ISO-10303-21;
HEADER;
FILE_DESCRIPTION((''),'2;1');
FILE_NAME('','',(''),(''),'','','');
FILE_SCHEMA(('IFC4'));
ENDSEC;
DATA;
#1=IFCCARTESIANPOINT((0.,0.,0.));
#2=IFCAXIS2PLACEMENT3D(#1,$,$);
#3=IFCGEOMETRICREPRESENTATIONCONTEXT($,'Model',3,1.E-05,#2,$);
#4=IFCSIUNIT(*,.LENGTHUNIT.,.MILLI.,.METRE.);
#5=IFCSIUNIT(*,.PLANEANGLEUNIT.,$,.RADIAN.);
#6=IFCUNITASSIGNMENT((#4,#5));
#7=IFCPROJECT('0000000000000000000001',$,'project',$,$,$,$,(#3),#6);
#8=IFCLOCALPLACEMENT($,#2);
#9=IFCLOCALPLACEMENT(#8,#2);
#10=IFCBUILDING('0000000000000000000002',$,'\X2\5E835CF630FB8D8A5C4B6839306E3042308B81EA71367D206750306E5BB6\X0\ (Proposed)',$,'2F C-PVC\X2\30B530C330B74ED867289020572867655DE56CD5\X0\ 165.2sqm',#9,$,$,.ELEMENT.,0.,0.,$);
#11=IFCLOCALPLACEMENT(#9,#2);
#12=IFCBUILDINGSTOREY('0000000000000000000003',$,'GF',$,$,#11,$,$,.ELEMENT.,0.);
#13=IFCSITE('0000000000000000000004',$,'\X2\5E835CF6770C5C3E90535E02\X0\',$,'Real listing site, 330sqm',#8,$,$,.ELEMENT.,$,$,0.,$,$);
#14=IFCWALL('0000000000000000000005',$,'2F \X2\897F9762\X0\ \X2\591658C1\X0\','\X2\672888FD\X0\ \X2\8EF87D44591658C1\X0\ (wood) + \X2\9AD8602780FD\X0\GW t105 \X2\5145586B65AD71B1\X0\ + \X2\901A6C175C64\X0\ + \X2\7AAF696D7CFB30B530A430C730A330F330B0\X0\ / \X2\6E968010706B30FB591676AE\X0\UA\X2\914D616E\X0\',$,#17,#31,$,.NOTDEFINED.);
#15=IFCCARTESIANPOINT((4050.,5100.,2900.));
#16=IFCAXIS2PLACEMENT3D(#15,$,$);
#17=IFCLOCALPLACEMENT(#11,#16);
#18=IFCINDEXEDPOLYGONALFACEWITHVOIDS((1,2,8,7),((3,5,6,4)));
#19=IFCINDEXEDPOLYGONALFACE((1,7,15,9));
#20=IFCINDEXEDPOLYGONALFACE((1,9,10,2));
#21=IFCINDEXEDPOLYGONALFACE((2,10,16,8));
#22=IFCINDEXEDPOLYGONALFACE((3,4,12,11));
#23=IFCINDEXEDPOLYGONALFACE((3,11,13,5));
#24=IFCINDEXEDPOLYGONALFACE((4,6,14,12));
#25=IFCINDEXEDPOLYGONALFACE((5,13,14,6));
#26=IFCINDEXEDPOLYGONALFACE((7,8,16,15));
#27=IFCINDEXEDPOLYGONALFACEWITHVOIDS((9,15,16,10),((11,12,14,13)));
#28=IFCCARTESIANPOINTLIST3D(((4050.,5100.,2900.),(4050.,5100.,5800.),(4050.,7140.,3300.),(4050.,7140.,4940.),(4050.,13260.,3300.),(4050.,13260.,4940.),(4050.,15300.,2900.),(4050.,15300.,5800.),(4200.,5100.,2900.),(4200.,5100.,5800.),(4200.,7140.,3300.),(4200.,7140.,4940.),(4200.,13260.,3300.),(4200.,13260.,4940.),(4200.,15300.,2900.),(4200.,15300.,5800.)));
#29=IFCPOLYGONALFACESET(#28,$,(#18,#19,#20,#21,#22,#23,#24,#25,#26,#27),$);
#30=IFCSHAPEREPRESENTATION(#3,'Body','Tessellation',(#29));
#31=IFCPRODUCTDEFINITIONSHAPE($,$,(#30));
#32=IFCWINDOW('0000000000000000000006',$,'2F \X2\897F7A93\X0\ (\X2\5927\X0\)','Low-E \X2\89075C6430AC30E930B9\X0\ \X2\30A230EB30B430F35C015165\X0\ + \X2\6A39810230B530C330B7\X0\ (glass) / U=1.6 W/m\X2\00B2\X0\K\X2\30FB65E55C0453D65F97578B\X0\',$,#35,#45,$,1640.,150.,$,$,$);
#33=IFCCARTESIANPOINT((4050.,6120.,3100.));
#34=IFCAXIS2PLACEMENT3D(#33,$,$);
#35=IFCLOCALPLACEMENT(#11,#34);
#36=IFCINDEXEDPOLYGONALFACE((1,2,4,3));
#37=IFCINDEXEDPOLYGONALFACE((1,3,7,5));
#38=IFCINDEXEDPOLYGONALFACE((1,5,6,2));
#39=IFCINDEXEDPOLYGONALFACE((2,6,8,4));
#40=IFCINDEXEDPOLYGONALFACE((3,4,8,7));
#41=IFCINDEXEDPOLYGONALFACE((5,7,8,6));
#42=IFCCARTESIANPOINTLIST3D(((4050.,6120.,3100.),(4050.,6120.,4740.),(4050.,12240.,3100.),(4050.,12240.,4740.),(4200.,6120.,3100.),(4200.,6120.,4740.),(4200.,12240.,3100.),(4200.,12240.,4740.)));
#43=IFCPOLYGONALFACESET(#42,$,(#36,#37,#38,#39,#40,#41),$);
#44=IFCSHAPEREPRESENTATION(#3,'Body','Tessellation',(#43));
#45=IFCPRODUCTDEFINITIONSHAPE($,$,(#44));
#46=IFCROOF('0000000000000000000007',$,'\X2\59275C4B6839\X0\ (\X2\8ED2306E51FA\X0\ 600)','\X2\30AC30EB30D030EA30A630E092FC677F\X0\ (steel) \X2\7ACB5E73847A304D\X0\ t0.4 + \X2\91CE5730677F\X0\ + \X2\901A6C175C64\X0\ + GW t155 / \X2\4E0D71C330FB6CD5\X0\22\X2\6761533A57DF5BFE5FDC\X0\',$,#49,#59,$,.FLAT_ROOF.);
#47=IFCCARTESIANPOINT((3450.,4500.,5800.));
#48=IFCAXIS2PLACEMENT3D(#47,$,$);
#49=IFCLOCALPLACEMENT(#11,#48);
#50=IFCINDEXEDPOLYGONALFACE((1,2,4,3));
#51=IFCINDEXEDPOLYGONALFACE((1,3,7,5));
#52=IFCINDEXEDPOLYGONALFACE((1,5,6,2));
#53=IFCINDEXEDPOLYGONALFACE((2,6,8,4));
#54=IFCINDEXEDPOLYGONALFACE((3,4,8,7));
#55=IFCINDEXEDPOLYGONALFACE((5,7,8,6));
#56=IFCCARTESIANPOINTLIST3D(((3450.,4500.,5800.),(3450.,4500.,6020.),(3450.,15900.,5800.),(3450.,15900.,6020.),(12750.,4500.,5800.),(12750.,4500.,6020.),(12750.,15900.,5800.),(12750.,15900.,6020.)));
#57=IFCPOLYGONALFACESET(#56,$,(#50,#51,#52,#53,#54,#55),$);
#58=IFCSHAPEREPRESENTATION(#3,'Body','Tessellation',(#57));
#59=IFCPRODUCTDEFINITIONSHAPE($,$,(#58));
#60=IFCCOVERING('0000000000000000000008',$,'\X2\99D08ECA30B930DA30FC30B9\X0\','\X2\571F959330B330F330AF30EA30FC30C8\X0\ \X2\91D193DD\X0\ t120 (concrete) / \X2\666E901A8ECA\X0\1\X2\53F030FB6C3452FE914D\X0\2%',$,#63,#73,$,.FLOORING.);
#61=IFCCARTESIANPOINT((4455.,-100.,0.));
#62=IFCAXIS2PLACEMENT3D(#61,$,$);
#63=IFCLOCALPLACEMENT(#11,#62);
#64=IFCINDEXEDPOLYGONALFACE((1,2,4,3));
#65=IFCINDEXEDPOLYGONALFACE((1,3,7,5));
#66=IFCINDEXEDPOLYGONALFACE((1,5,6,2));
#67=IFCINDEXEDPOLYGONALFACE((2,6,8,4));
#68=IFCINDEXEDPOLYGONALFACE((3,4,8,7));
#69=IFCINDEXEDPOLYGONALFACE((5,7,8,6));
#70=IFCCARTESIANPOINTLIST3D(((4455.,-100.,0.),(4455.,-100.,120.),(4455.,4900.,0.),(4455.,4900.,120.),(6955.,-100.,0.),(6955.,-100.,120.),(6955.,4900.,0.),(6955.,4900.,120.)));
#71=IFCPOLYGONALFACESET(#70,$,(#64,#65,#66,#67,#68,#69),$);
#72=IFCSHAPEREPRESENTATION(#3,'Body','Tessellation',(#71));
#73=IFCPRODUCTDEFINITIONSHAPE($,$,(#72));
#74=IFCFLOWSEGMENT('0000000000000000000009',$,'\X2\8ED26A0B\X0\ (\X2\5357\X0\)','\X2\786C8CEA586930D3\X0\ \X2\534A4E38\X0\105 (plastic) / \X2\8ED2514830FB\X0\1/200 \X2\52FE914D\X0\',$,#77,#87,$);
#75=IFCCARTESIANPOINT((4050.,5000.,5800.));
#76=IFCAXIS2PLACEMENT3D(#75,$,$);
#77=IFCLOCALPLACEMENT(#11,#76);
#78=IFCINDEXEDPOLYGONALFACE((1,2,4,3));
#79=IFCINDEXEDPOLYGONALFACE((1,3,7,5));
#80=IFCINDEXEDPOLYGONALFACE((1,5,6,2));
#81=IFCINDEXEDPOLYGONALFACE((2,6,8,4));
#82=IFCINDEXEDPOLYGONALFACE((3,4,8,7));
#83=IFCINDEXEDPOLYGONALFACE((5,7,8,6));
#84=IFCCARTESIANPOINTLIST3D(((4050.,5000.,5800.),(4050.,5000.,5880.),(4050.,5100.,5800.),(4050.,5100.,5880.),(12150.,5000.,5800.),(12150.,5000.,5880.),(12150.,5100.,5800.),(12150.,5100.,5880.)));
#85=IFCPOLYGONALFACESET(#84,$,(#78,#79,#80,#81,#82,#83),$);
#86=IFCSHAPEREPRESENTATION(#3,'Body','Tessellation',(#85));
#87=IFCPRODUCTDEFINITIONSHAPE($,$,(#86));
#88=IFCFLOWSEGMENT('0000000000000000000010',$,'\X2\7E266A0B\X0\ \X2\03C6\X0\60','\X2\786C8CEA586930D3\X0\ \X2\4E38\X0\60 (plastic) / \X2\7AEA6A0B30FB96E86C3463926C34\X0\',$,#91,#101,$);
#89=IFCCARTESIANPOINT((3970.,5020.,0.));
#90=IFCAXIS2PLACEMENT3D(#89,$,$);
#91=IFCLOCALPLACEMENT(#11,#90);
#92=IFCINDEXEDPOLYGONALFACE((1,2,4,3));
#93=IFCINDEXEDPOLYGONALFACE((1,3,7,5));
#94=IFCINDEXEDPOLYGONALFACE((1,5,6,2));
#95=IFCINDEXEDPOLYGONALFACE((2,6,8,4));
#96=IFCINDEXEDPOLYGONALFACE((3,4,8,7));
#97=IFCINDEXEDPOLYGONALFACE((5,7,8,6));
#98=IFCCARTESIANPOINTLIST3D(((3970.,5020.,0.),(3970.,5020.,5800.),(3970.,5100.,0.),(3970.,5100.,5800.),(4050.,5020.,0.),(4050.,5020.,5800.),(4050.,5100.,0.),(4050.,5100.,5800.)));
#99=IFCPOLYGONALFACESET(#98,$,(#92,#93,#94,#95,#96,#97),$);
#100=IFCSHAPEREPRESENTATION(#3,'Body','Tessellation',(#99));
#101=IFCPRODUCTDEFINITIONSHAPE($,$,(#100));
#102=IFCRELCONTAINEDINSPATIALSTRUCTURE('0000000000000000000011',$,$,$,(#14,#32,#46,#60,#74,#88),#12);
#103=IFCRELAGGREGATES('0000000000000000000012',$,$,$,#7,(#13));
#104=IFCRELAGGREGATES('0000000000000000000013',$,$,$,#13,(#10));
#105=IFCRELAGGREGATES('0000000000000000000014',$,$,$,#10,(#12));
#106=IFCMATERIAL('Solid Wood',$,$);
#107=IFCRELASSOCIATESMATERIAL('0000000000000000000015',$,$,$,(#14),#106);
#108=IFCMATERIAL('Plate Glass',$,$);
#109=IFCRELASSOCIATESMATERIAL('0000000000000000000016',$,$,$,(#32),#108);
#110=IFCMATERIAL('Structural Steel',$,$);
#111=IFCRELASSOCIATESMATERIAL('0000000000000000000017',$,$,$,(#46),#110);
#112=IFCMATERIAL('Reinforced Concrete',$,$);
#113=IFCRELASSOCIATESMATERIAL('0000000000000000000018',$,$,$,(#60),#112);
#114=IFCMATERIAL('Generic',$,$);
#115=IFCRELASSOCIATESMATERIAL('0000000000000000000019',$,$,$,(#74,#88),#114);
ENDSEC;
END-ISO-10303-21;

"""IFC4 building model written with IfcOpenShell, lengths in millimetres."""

from ifc_helpers import new_model, si_unit, frame, frame_2d, origin, place, context, project, spatial, rectangle, extrude, material, element, fill, save


model = new_model("IFC4")

# Units and contexts
model_context = context("Model", 3, precision=1e-05, world=origin())
ifc_project = project(units=[si_unit("LENGTHUNIT", "METRE", prefix="MILLI"), si_unit("PLANEANGLEUNIT", "RADIAN")], contexts=[model_context])

# Site, building, storey
site_placement = place(None, origin())
site = spatial("IfcSite", under=ifc_project, at=site_placement, Name="広島県尾道市", ObjectType="Real listing site, 330sqm", CompositionType="ELEMENT", RefElevation=0.0)
building_placement = place(site_placement, origin())
building = spatial("IfcBuilding", under=site, at=building_placement, Name="広島・越屋根のある自然素材の家 (Proposed)", ObjectType="2F C-PVCサッシ付木造在来工法 165.2sqm", CompositionType="ELEMENT", ElevationOfRefHeight=0.0, ElevationOfTerrain=0.0)
storey_placement = place(building_placement, origin())
storey = spatial("IfcBuildingStorey", under=building, at=storey_placement, Name="GF", CompositionType="ELEMENT", Elevation=0.0)

# Shared definitions
ifc_material_1 = material(Name="Solid Wood")

# Shared definitions
ifc_material_2 = material(Name="Reinforced Concrete")

# Shared definitions
ifc_material_3 = material(Name="Plate Glass")

# Wall, opening, window
wall_1_placement = place(storey_placement, frame((4050.0, 5100.0, 2900.0)))
wall_1 = element("IfcWall", 1, at=wall_1_placement, inside=storey, material=ifc_material_1, Name="2F 西面 外壁", Description="木製 軸組外壁 (wood) + 高性能GW t105 充填断熱 + 通気層 + 窯業系サイディング / 準耐火・外皮UA配慮", PredefinedType="NOTDEFINED", context=model_context, shape_type="SweptSolid", body=[
    extrude(rectangle(XDim=150.0, YDim=10200.0, at=frame_2d((75.0, 5100.0))), frame((4050.0, 5100.0, 2900.0)), (0.0, 0.0, 1.0), 2900.0),
])
opening_1_placement = place(storey_placement, frame((4050.0, 6120.0, 3100.0)))
opening_1 = element("IfcOpeningElement", 2, at=opening_1_placement, cuts=wall_1, PredefinedType="NOTDEFINED", context=model_context, shape_type="SweptSolid", body=[
    extrude(rectangle(XDim=150.0, YDim=6120.0, at=frame_2d((75.0, 3060.0))), frame((4050.0, 6120.0, 3100.0)), (0.0, 0.0, 1.0), 1640.0),
])
window_1_placement = place(storey_placement, frame((4050.0, 6120.0, 3100.0)))
window_1 = element("IfcWindow", 3, at=window_1_placement, inside=storey, material=ifc_material_3, Name="2F 西窓 (大)", Description="Low-E 複層ガラス アルゴン封入 + 樹脂サッシ (glass) / U=1.6 W/m²K・日射取得型", OverallHeight=1640.0, OverallWidth=150.0, context=model_context, shape_type="SweptSolid", body=[
    extrude(rectangle(XDim=150.0, YDim=6120.0, at=frame_2d((75.0, 3060.0))), frame((4050.0, 6120.0, 3100.0)), (0.0, 0.0, 1.0), 1640.0),
])
fill(opening_1, window_1)

# Roof
ifc_material_4 = material(Name="Structural Steel")
roof_placement = place(storey_placement, frame((3450.0, 4500.0, 5800.0)))
element("IfcRoof", 4, at=roof_placement, inside=storey, material=ifc_material_4, Name="大屋根 (軒の出 600)", Description="ガルバリウム鋼板 (steel) 立平葺き t0.4 + 野地板 + 通気層 + GW t155 / 不燃・法22条区域対応", PredefinedType="FLAT_ROOF", context=model_context, shape_type="SweptSolid", body=[
    extrude(rectangle(XDim=9300.0, YDim=11400.0, at=frame_2d((4650.0, 5700.0))), frame((3450.0, 4500.0, 5800.0)), (0.0, 0.0, 1.0), 220.0),
])

# Covering
covering_placement = place(storey_placement, frame((4455.0, -100.0, 0.0)))
element("IfcCovering", 5, at=covering_placement, inside=storey, material=ifc_material_2, Name="駐車スペース", Description="土間コンクリート 金鏝 t120 (concrete) / 普通車1台・水勾配2%", PredefinedType="FLOORING", context=model_context, shape_type="SweptSolid", body=[
    extrude(rectangle(XDim=2500.0, YDim=5000.0, at=frame_2d((1250.0, 2500.0))), frame((4455.0, -100.0, 0.0)), (0.0, 0.0, 1.0), 120.0),
])

# Flow segments
ifc_material_5 = material(Name="Generic")
flow_segment_1_placement = place(storey_placement, frame((4050.0, 5000.0, 5800.0)))
element("IfcFlowSegment", 6, at=flow_segment_1_placement, inside=storey, material=ifc_material_5, Name="軒樋 (南)", Description="硬質塩ビ 半丸105 (plastic) / 軒先・1/200 勾配", context=model_context, shape_type="SweptSolid", body=[
    extrude(rectangle(XDim=8100.0, YDim=100.0, at=frame_2d((4050.0, 50.0))), frame((4050.0, 5000.0, 5800.0)), (0.0, 0.0, 1.0), 80.0),
])
flow_segment_2_placement = place(storey_placement, frame((3970.0, 5020.0, 0.0)))
element("IfcFlowSegment", 7, at=flow_segment_2_placement, inside=storey, material=ifc_material_5, Name="縦樋 φ60", Description="硬質塩ビ 丸60 (plastic) / 竪樋・雨水排水", context=model_context, shape_type="SweptSolid", body=[
    extrude(rectangle(XDim=80.0, YDim=80.0, at=frame_2d((40.0, 40.0))), frame((3970.0, 5020.0, 0.0)), (0.0, 0.0, 1.0), 5800.0),
])

save(model, "model.ifc")
